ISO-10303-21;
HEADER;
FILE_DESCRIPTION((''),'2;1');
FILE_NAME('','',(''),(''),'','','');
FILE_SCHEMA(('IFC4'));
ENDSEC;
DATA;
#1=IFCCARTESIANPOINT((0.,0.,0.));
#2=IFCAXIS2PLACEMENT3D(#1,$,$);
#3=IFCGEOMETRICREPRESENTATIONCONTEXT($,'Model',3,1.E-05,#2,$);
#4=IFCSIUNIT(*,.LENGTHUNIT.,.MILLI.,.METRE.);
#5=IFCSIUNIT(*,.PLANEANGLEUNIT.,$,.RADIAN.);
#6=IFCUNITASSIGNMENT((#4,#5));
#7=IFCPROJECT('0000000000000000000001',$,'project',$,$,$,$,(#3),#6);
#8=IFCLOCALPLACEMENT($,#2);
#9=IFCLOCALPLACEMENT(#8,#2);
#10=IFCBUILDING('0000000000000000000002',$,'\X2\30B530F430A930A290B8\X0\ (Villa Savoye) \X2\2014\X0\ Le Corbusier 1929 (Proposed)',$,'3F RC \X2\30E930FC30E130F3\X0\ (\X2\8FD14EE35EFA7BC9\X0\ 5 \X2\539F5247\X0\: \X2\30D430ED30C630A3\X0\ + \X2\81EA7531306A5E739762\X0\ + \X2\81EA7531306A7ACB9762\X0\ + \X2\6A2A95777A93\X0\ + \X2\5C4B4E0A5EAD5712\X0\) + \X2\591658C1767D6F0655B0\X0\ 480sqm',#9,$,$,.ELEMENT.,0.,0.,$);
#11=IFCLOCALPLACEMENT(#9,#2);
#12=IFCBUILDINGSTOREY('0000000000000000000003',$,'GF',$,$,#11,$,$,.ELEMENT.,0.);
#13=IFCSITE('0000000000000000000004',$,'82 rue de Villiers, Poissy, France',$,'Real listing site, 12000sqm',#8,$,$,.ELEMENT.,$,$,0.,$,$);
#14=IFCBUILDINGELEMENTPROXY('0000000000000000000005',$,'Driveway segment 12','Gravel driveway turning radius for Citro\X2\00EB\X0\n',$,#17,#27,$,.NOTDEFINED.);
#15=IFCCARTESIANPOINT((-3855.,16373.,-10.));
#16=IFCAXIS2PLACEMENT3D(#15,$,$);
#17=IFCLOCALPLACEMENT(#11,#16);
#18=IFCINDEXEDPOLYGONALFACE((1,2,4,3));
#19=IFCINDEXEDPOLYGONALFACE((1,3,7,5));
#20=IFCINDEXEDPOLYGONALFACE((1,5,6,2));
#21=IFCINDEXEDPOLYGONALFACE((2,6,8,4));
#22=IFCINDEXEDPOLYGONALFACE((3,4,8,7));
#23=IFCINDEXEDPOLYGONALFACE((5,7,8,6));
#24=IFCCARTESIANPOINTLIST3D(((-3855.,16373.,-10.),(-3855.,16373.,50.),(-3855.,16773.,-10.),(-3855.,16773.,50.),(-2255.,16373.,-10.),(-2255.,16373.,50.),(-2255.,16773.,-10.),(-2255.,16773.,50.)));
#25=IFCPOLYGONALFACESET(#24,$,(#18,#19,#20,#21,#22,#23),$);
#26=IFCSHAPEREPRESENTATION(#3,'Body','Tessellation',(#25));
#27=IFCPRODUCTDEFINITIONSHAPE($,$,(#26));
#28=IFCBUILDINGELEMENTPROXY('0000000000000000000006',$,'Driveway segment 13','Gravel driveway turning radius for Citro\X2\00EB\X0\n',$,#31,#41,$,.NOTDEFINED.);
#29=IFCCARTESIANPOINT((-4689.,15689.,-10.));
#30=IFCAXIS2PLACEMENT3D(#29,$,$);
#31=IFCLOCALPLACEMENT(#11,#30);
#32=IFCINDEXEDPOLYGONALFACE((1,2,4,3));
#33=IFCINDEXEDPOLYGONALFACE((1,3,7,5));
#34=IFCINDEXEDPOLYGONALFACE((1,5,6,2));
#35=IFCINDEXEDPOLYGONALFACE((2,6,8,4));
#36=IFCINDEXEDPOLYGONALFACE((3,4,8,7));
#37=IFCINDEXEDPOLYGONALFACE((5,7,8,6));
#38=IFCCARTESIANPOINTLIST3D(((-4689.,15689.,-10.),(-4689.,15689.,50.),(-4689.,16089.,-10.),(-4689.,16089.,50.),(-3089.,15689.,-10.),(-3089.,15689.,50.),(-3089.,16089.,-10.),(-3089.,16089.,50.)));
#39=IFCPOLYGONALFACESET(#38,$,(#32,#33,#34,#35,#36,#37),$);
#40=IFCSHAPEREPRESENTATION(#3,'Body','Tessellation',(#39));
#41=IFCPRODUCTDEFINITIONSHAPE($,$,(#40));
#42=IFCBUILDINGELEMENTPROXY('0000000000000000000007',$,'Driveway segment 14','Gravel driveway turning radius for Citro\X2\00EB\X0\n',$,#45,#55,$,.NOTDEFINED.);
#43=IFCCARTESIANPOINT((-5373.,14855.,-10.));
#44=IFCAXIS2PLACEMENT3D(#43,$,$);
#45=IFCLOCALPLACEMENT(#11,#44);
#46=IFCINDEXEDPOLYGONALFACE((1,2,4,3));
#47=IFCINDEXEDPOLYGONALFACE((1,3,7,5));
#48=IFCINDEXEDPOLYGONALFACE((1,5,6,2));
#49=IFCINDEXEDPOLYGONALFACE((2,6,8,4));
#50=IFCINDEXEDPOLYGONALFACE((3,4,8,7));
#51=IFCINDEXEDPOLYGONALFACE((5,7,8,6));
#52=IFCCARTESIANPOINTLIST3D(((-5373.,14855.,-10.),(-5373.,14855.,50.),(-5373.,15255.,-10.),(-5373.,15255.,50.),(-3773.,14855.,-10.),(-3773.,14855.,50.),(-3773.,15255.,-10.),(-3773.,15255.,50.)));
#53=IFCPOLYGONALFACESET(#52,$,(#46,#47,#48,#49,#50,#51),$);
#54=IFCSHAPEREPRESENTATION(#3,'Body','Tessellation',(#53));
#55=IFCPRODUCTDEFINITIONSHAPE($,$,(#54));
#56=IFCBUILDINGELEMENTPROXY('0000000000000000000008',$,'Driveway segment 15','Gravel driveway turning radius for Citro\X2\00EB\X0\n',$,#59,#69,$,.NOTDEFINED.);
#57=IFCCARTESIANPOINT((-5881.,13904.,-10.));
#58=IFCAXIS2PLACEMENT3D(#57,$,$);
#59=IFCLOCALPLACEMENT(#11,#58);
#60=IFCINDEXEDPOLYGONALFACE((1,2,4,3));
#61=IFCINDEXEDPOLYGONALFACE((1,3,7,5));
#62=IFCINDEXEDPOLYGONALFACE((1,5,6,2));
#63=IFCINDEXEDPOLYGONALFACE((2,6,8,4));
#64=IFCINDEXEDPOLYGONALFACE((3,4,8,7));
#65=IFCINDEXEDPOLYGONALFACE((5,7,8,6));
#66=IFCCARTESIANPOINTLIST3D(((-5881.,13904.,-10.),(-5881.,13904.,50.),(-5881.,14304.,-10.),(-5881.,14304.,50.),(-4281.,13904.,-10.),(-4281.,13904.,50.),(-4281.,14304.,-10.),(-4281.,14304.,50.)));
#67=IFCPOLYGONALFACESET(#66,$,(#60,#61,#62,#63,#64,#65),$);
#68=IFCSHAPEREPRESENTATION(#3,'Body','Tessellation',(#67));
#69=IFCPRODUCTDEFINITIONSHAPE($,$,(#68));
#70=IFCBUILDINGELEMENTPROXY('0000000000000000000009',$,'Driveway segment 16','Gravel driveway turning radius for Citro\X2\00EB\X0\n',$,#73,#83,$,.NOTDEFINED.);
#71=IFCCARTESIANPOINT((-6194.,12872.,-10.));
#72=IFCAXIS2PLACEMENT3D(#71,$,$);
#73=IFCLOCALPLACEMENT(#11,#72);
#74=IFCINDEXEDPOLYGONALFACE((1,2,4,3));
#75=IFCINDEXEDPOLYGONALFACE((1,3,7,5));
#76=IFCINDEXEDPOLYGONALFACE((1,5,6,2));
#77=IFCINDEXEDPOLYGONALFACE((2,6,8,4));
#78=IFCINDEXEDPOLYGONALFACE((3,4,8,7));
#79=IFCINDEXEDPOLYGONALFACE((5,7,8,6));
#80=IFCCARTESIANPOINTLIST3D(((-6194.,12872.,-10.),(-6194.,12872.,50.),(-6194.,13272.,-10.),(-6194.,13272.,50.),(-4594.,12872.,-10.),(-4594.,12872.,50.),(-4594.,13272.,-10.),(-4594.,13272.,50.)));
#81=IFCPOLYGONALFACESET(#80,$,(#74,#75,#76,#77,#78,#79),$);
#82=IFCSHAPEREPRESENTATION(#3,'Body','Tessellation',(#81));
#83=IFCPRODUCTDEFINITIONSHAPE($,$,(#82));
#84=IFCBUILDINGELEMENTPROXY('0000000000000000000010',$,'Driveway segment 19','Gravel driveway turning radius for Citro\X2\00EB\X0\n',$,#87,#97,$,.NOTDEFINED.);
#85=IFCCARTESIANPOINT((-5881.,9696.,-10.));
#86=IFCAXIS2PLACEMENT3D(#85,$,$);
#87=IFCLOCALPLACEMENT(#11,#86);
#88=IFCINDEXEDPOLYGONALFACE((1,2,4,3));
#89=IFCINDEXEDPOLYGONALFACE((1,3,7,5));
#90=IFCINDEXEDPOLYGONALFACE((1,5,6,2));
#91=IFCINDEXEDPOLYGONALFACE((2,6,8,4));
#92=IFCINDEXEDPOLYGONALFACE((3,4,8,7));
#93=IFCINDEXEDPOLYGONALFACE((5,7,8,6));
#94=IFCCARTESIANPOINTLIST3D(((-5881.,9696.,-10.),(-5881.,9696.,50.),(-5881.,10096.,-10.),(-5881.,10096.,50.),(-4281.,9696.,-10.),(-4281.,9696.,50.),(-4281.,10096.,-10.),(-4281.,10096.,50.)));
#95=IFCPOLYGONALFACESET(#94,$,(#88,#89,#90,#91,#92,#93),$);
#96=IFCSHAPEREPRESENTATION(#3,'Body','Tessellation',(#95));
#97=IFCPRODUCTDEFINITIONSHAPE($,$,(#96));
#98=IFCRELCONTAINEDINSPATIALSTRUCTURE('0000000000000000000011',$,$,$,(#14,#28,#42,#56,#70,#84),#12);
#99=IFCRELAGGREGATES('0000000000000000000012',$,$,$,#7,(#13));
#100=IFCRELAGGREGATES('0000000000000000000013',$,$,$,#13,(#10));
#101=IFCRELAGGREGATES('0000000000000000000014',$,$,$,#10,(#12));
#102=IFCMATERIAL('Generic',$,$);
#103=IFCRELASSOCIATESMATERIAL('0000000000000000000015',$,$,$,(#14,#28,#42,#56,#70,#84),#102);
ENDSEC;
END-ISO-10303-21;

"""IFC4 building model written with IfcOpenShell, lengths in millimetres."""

from ifc_helpers import new_model, si_unit, frame, frame_2d, origin, place, context, project, spatial, rectangle, extrude, material, element, save


model = new_model("IFC4")

# Units and contexts
model_context = context("Model", 3, precision=1e-05, world=origin())
ifc_project = project(units=[si_unit("LENGTHUNIT", "METRE", prefix="MILLI"), si_unit("PLANEANGLEUNIT", "RADIAN")], contexts=[model_context])

# Site, building, storey
site_placement = place(None, origin())
site = spatial("IfcSite", under=ifc_project, at=site_placement, Name="82 rue de Villiers, Poissy, France", ObjectType="Real listing site, 12000sqm", CompositionType="ELEMENT", RefElevation=0.0)
building_placement = place(site_placement, origin())
building = spatial("IfcBuilding", under=site, at=building_placement, Name="サヴォア邸 (Villa Savoye) — Le Corbusier 1929 (Proposed)", ObjectType="3F RC ラーメン (近代建築 5 原則: ピロティ + 自由な平面 + 自由な立面 + 横長窓 + 屋上庭園) + 外壁白漆喰 480sqm", CompositionType="ELEMENT", ElevationOfRefHeight=0.0, ElevationOfTerrain=0.0)
storey_placement = place(building_placement, origin())
storey = spatial("IfcBuildingStorey", under=building, at=storey_placement, Name="GF", CompositionType="ELEMENT", Elevation=0.0)

# Shared definitions
ifc_material_1 = material(Name="Generic")

# Building element proxies
proxy_1_placement = place(storey_placement, frame((-3855.0, 16373.0, -10.0)))
element("IfcBuildingElementProxy", 1, at=proxy_1_placement, inside=storey, material=ifc_material_1, Name="Driveway segment 12", Description="Gravel driveway turning radius for Citroën", PredefinedType="NOTDEFINED", context=model_context, shape_type="SweptSolid", body=[
    extrude(rectangle(XDim=1600.0, YDim=400.0, at=frame_2d((800.0, 200.0))), frame((-3855.0, 16373.0, -10.0)), (0.0, 0.0, 1.0), 60.0),
])
proxy_2_placement = place(storey_placement, frame((-4689.0, 15689.0, -10.0)))
element("IfcBuildingElementProxy", 2, at=proxy_2_placement, inside=storey, material=ifc_material_1, Name="Driveway segment 13", Description="Gravel driveway turning radius for Citroën", PredefinedType="NOTDEFINED", context=model_context, shape_type="SweptSolid", body=[
    extrude(rectangle(XDim=1600.0, YDim=400.0, at=frame_2d((800.0, 200.0))), frame((-4689.0, 15689.0, -10.0)), (0.0, 0.0, 1.0), 60.0),
])
proxy_3_placement = place(storey_placement, frame((-5373.0, 14855.0, -10.0)))
element("IfcBuildingElementProxy", 3, at=proxy_3_placement, inside=storey, material=ifc_material_1, Name="Driveway segment 14", Description="Gravel driveway turning radius for Citroën", PredefinedType="NOTDEFINED", context=model_context, shape_type="SweptSolid", body=[
    extrude(rectangle(XDim=1600.0, YDim=400.0, at=frame_2d((800.0, 200.0))), frame((-5373.0, 14855.0, -10.0)), (0.0, 0.0, 1.0), 60.0),
])
proxy_4_placement = place(storey_placement, frame((-5881.0, 13904.0, -10.0)))
element("IfcBuildingElementProxy", 4, at=proxy_4_placement, inside=storey, material=ifc_material_1, Name="Driveway segment 15", Description="Gravel driveway turning radius for Citroën", PredefinedType="NOTDEFINED", context=model_context, shape_type="SweptSolid", body=[
    extrude(rectangle(XDim=1600.0, YDim=400.0, at=frame_2d((800.0, 200.0))), frame((-5881.0, 13904.0, -10.0)), (0.0, 0.0, 1.0), 60.0),
])
proxy_5_placement = place(storey_placement, frame((-6194.0, 12872.0, -10.0)))
element("IfcBuildingElementProxy", 5, at=proxy_5_placement, inside=storey, material=ifc_material_1, Name="Driveway segment 16", Description="Gravel driveway turning radius for Citroën", PredefinedType="NOTDEFINED", context=model_context, shape_type="SweptSolid", body=[
    extrude(rectangle(XDim=1600.0, YDim=400.0, at=frame_2d((800.0, 200.0))), frame((-6194.0, 12872.0, -10.0)), (0.0, 0.0, 1.0), 60.0),
])
proxy_6_placement = place(storey_placement, frame((-5881.0, 9696.0, -10.0)))
element("IfcBuildingElementProxy", 6, at=proxy_6_placement, inside=storey, material=ifc_material_1, Name="Driveway segment 19", Description="Gravel driveway turning radius for Citroën", PredefinedType="NOTDEFINED", context=model_context, shape_type="SweptSolid", body=[
    extrude(rectangle(XDim=1600.0, YDim=400.0, at=frame_2d((800.0, 200.0))), frame((-5881.0, 9696.0, -10.0)), (0.0, 0.0, 1.0), 60.0),
])

save(model, "model.ifc")
